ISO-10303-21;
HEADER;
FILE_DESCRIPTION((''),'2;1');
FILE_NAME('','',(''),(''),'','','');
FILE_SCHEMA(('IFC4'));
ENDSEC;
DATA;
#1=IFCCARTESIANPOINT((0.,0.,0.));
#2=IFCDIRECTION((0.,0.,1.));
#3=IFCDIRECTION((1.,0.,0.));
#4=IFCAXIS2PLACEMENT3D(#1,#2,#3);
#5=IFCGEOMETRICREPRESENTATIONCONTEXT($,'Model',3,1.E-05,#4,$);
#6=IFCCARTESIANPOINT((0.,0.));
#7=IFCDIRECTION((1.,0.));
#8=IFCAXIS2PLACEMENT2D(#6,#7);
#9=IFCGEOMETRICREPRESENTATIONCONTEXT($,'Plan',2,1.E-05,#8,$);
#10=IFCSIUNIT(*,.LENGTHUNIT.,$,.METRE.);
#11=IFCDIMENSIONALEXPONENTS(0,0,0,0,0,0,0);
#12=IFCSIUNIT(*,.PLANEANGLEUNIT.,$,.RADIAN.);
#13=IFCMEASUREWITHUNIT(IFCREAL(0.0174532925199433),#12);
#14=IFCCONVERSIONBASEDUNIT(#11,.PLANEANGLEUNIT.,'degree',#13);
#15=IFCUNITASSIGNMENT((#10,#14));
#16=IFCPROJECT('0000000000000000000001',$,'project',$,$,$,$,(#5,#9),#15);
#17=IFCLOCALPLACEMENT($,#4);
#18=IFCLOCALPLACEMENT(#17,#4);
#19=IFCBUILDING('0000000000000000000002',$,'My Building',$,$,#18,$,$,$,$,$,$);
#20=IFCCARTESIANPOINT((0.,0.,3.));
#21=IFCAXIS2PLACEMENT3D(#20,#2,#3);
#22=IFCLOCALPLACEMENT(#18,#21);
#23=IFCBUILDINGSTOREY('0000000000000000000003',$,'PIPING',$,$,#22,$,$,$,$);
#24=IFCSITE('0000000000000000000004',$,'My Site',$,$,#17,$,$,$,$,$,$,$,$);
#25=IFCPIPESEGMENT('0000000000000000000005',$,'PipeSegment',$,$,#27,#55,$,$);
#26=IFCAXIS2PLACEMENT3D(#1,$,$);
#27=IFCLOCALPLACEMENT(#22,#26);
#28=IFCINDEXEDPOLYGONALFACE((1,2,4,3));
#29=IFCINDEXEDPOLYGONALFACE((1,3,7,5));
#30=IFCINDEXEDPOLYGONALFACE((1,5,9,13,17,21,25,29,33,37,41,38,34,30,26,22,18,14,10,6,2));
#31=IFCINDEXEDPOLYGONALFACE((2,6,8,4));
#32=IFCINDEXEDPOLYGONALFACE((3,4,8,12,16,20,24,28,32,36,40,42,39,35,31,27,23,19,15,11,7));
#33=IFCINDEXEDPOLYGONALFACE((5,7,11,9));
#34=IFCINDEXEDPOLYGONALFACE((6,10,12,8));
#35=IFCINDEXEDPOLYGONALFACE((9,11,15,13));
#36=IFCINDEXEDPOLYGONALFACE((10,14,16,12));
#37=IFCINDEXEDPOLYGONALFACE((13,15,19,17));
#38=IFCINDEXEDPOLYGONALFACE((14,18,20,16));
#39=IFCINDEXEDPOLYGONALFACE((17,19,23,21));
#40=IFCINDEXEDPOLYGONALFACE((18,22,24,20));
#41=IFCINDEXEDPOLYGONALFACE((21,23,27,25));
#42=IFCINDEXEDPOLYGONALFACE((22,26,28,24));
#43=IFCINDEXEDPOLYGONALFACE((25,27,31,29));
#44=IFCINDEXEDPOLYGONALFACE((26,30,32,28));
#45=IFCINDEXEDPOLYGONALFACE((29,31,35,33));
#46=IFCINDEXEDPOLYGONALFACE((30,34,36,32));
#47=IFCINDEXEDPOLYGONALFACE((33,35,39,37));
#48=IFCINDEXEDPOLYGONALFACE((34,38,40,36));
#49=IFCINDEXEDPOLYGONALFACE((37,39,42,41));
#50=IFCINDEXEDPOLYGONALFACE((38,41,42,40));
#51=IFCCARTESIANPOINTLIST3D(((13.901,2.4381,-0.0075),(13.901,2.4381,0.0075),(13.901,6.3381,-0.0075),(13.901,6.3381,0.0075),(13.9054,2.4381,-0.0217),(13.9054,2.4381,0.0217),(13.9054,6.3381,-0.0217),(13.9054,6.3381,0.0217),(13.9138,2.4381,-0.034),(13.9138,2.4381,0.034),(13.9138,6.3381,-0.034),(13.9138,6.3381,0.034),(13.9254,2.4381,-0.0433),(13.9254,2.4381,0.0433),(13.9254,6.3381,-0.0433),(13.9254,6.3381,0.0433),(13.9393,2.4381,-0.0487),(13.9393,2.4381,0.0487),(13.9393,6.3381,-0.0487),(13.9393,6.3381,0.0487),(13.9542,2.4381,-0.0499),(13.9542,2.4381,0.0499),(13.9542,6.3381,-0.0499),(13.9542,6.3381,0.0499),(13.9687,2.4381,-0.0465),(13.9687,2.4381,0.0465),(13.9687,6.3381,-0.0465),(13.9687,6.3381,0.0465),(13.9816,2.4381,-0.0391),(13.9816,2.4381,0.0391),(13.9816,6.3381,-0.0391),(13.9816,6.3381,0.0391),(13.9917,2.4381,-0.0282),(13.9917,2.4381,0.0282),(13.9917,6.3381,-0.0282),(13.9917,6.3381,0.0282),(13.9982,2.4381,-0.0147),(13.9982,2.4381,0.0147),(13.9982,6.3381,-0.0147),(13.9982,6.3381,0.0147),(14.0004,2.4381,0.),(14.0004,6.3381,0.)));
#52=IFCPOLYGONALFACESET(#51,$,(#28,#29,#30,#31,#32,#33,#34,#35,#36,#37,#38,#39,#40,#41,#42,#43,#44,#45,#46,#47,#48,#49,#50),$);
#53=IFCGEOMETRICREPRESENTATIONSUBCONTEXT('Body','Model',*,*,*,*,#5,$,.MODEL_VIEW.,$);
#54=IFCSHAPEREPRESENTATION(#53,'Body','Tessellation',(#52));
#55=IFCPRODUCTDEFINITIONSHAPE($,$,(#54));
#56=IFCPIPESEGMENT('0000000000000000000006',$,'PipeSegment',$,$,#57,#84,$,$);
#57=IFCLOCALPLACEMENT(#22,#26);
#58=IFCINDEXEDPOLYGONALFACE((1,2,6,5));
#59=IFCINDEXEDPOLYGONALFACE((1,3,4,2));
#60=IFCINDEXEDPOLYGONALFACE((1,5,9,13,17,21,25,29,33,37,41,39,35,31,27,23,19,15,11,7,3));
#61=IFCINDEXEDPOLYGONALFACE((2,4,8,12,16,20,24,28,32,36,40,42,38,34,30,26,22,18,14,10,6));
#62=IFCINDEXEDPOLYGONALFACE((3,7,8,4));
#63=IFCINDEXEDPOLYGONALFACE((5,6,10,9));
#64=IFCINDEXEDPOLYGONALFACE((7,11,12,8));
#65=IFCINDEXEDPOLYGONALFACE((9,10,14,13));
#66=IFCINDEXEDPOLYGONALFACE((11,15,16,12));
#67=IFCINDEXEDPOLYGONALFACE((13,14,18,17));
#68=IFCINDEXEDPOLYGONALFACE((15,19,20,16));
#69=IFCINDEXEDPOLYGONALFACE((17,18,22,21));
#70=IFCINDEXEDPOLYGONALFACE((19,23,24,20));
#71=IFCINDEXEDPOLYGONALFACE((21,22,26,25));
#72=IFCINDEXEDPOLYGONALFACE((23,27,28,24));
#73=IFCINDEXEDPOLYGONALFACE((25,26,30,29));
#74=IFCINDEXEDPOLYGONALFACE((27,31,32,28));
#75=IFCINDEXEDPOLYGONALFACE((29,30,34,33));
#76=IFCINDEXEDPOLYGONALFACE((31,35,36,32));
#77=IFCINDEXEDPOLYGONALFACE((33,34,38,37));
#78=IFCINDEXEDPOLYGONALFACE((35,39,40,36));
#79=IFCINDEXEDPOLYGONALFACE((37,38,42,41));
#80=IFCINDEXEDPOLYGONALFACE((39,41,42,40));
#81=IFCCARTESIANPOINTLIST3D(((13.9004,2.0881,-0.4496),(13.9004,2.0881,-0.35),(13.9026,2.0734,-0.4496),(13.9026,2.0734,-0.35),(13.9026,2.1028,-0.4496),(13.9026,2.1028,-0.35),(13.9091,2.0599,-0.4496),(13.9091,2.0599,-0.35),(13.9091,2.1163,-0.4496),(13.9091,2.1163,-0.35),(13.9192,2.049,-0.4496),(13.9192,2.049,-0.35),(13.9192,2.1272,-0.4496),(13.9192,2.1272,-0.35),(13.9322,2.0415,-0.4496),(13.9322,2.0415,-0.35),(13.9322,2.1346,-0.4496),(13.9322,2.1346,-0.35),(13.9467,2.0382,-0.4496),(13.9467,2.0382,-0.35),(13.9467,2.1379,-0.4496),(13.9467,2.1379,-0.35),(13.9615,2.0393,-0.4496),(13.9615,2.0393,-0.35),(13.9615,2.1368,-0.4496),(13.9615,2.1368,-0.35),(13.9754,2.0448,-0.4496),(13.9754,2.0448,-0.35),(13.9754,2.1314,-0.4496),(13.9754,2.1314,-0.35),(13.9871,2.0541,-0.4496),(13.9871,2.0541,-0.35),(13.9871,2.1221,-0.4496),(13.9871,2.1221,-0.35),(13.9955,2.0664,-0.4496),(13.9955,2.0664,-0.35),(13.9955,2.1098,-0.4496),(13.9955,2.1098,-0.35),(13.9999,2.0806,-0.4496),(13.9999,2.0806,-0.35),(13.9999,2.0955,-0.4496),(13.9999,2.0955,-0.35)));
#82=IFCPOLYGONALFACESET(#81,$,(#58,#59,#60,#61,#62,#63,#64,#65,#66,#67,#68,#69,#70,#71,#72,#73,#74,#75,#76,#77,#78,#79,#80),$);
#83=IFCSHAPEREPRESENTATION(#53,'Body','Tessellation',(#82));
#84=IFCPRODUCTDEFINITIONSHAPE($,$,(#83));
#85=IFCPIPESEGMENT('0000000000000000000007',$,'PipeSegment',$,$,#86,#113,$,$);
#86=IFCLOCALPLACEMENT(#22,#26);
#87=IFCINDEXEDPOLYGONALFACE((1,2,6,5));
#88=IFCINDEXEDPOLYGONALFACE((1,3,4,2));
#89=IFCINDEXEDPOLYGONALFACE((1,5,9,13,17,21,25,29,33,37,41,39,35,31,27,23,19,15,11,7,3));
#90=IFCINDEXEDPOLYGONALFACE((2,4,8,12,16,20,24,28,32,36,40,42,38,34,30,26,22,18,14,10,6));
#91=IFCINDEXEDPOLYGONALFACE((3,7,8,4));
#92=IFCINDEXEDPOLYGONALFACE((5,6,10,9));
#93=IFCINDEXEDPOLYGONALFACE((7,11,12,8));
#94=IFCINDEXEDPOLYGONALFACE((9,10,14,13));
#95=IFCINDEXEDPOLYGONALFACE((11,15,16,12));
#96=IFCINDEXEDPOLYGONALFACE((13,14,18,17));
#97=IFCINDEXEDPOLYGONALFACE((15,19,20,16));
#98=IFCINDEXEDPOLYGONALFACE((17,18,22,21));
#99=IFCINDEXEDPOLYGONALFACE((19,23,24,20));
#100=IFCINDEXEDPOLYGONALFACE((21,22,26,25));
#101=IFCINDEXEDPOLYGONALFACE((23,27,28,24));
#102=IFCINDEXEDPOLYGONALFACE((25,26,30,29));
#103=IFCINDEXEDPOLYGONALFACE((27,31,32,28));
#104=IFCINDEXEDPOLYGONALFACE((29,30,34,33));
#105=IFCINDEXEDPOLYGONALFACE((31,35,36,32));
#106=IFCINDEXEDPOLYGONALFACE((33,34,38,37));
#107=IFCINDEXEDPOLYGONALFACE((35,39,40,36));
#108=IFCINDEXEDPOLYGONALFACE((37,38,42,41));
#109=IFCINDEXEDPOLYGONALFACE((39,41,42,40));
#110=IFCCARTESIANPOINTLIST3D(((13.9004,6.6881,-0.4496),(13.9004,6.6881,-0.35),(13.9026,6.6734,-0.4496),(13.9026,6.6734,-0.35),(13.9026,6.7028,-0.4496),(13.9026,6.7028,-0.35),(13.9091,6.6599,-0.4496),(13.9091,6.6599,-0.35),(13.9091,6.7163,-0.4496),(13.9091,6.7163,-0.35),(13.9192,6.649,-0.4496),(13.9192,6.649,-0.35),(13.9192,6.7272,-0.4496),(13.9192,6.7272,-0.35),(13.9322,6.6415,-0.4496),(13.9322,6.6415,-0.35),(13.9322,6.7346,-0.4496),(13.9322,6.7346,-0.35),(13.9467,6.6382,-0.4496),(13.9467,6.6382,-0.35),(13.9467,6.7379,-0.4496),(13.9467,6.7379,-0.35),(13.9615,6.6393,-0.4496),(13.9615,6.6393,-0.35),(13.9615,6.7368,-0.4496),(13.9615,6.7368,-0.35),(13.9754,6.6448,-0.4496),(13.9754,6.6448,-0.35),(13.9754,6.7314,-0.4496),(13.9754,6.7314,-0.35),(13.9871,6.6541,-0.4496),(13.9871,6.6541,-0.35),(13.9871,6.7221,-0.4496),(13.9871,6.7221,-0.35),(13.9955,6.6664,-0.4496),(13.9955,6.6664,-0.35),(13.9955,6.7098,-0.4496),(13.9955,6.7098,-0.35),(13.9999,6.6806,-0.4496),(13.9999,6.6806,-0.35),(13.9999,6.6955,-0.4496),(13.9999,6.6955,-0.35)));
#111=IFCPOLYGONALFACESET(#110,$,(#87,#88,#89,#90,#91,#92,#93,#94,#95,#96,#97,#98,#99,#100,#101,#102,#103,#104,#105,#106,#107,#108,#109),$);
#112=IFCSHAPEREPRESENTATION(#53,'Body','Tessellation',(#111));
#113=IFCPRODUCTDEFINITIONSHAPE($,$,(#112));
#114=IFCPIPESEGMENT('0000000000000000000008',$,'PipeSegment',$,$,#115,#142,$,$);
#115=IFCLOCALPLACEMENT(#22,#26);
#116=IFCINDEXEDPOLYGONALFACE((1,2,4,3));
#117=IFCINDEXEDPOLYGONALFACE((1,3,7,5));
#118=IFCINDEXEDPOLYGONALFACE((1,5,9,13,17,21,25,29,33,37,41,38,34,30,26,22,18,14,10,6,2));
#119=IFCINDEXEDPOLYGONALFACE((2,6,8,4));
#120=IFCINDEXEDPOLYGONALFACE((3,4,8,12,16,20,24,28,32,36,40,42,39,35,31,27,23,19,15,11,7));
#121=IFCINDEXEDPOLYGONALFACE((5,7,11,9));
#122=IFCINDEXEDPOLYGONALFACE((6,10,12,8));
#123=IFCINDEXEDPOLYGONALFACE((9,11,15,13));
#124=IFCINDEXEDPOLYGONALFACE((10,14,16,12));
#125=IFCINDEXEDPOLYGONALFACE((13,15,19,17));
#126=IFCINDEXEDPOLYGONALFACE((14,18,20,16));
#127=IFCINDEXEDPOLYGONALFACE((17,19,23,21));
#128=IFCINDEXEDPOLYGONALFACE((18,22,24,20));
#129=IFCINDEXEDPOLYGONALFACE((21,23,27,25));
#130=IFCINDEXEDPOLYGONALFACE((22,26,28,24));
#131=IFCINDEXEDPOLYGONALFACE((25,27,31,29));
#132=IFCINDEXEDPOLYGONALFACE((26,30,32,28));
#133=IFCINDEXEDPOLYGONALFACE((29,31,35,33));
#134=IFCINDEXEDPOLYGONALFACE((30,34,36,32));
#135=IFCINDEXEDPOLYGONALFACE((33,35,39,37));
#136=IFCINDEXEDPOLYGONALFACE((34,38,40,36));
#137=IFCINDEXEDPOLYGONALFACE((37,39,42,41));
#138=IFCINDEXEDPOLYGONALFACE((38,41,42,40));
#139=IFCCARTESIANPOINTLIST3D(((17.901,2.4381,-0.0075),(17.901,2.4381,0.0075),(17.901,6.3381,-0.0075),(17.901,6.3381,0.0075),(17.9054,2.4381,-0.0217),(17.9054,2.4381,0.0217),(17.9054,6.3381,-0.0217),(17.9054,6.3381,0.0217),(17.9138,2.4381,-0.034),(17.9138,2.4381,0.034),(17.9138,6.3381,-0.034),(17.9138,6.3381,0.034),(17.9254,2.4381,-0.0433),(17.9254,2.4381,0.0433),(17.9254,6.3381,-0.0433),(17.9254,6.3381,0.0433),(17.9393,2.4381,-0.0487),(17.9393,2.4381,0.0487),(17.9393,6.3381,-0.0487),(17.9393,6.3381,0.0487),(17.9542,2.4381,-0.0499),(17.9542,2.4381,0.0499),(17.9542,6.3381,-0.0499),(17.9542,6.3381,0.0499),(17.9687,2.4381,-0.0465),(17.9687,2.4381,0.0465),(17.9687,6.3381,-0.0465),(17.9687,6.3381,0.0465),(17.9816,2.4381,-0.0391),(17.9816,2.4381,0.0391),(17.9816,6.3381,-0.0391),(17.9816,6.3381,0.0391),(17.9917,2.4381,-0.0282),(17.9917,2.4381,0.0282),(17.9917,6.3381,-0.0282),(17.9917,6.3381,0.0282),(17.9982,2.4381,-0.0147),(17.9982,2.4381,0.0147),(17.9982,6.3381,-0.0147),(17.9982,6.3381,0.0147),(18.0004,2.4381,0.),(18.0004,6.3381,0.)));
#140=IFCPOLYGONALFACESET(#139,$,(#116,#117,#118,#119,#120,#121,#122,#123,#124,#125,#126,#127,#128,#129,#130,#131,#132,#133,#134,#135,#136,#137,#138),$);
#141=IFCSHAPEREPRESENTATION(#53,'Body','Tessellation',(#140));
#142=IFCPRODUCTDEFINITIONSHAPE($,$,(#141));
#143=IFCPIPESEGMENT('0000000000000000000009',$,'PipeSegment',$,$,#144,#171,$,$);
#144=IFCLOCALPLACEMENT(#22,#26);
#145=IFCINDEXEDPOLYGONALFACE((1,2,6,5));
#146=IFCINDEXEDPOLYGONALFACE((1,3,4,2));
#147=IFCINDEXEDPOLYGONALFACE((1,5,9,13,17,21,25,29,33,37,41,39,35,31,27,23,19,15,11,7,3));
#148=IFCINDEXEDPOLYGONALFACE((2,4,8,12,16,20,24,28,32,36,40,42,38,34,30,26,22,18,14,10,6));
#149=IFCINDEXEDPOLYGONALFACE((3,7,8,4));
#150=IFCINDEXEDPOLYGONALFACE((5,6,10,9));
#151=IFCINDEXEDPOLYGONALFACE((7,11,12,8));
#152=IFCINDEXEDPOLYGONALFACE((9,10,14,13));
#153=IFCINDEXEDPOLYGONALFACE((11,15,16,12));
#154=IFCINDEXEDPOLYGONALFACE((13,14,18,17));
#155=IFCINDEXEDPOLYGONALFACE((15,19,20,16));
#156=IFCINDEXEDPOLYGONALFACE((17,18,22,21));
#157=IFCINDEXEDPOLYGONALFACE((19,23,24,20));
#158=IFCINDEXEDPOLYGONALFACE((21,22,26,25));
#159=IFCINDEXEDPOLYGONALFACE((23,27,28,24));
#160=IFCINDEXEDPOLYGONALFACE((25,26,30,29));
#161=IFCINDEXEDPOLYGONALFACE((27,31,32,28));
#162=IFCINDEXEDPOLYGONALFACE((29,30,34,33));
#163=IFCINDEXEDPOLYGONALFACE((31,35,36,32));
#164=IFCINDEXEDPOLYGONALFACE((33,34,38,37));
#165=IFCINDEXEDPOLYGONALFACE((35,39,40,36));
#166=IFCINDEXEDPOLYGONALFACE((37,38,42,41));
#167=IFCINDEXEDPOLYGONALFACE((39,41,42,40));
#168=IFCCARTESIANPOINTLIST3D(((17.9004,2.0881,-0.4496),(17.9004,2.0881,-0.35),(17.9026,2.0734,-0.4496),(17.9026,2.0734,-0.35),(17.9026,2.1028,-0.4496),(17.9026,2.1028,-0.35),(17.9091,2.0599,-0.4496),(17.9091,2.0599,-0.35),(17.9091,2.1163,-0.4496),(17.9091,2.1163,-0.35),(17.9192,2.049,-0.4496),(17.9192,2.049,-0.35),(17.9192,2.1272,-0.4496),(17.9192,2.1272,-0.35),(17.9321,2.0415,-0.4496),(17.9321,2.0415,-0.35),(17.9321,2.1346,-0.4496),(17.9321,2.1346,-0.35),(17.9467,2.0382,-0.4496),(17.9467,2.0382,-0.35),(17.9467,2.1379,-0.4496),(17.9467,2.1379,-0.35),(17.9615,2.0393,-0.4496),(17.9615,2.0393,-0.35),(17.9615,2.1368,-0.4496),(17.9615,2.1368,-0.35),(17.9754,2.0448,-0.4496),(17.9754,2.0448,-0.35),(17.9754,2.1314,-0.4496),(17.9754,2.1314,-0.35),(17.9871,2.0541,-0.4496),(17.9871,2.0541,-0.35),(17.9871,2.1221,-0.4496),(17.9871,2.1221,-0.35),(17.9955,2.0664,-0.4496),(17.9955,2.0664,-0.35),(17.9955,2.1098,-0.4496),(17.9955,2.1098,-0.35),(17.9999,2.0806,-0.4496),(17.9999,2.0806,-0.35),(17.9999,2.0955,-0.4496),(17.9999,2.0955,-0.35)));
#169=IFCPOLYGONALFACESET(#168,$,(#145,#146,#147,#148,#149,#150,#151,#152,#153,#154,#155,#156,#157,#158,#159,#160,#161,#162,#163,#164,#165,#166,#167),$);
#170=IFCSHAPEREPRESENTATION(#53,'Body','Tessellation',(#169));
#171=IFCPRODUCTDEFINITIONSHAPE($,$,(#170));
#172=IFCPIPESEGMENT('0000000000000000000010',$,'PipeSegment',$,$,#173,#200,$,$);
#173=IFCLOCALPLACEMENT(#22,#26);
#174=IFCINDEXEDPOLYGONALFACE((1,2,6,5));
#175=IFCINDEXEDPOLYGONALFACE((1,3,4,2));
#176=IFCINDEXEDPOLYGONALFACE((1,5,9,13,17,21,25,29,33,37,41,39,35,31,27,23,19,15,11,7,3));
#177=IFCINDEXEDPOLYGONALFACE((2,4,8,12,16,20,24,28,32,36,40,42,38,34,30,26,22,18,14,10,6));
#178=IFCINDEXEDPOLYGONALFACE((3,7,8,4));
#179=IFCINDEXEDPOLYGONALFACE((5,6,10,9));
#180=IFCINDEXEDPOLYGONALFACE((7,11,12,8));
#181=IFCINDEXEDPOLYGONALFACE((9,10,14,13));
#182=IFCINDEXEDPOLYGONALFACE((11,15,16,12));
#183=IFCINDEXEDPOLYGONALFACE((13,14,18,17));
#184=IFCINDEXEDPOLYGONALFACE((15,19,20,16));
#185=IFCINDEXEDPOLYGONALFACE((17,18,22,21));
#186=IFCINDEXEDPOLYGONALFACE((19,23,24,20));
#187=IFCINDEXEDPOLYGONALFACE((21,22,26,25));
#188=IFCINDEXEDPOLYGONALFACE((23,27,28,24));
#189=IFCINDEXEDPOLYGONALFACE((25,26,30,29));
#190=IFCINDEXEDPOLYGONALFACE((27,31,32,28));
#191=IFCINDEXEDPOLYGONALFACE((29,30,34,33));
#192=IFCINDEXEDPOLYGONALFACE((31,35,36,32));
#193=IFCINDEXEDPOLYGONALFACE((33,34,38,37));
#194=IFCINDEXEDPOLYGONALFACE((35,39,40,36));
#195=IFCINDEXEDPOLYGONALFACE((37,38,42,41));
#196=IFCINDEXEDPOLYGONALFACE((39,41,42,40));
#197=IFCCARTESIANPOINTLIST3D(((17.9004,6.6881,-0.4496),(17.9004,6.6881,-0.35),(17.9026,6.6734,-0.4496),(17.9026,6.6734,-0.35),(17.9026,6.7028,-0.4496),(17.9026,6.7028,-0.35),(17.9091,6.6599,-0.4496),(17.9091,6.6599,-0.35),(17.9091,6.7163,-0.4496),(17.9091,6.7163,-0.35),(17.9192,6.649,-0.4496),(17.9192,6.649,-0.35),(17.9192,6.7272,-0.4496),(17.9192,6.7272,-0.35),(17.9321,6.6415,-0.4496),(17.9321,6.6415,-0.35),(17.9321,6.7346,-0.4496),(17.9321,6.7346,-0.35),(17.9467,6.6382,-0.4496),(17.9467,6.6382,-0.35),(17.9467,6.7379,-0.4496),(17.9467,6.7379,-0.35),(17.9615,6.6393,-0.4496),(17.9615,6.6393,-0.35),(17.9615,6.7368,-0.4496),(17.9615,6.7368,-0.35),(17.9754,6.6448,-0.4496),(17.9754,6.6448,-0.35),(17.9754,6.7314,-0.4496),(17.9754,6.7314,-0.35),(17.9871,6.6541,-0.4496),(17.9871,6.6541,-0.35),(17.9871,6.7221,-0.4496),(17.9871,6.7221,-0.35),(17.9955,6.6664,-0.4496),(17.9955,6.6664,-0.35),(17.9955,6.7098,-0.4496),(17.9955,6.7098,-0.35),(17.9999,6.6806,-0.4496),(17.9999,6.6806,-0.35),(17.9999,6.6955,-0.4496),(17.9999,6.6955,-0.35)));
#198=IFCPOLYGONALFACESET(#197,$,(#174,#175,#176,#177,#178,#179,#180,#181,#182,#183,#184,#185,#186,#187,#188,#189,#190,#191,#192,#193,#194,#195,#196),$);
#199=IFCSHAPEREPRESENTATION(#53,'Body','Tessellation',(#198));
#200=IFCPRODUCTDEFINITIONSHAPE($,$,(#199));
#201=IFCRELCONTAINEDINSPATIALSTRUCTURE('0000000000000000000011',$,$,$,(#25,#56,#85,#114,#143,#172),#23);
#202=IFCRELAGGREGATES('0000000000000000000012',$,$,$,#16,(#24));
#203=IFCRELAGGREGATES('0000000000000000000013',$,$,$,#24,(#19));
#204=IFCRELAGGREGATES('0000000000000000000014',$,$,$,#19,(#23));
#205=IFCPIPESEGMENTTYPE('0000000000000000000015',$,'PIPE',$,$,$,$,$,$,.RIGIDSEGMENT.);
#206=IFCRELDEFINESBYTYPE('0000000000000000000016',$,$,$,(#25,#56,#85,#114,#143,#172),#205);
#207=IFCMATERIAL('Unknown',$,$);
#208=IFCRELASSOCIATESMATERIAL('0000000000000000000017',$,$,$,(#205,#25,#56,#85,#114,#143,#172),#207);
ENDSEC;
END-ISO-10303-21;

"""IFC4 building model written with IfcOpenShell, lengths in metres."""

from ifc_helpers import new_model, entity, si_unit, converted_unit, frame, origin_with_axes, origin_2d_with_axis, place, context, subcontext, project, spatial, circle, extrude, material, material_profile, profile_set, profile_usage, type_object, element, save


model = new_model("IFC4")

# Units and contexts
model_context = context("Model", 3, precision=1e-05, world=origin_with_axes())
plan_context = context("Plan", 2, precision=1e-05, world=origin_2d_with_axis())
body_context = subcontext(model_context, "Body", "Model", "MODEL_VIEW")
ifc_project = project(units=[si_unit("LENGTHUNIT", "METRE"), converted_unit("PLANEANGLEUNIT", "degree", entity("IfcReal", 0.0174532925199433), si_unit("PLANEANGLEUNIT", "RADIAN"), dimensions=[0, 0, 0, 0, 0, 0, 0])], contexts=[model_context, plan_context])

# Site, building, storey
site_placement = place(None, origin_with_axes())
site = spatial("IfcSite", under=ifc_project, at=site_placement, Name="My Site")
building_placement = place(site_placement, origin_with_axes())
building = spatial("IfcBuilding", under=site, at=building_placement, Name="My Building")
storey_placement = place(building_placement, frame((0.0, 0.0, 3.0), z_axis=(0.0, 0.0, 1.0), x_axis=(1.0, 0.0, 0.0)))
storey = spatial("IfcBuildingStorey", under=building, at=storey_placement, Name="PIPING")

# Pipe segments
ifc_material = material(Name="Unknown")
ifc_material_profile = material_profile(ifc_material, circle(Radius=0.05))
ifc_profile_set = profile_set([ifc_material_profile])
pipe_segment_type = type_object("IfcPipeSegmentType", Name="PIPE", PredefinedType="RIGIDSEGMENT", material=ifc_profile_set)
ifc_profile_usage_1 = profile_usage(ifc_profile_set, cardinal=5)
pipe_segment_1_placement = place(storey_placement, frame((13.9504, 6.3381, 0.0), z_axis=(0.0, -1.0, 0.0), x_axis=(1.0, 0.0, 0.0)))
element("IfcPipeSegment", 1, at=pipe_segment_1_placement, inside=storey, type_object=pipe_segment_type, material=ifc_profile_usage_1, Name="PipeSegment", context=body_context, shape_type="SweptSolid", body=[
    extrude(circle(Radius=0.05), origin_with_axes(), (0.0, 0.0, 1.0), 3.9),
])
ifc_profile_usage_2 = profile_usage(ifc_profile_set, cardinal=5)
pipe_segment_2_placement = place(storey_placement, frame((13.9504, 2.0881, -0.35), z_axis=(0.0, 0.0, -1.0), x_axis=(-1.0, 0.0, 0.0)))
element("IfcPipeSegment", 2, at=pipe_segment_2_placement, inside=storey, type_object=pipe_segment_type, material=ifc_profile_usage_2, Name="PipeSegment", context=body_context, shape_type="SweptSolid", body=[
    extrude(circle(Radius=0.05), origin_with_axes(), (0.0, 0.0, 1.0), 0.0996),
])
ifc_profile_usage_3 = profile_usage(ifc_profile_set, cardinal=5)
pipe_segment_3_placement = place(storey_placement, frame((13.9504, 6.6881, -0.35), z_axis=(0.0, 0.0, -1.0), x_axis=(-1.0, 0.0, 0.0)))
element("IfcPipeSegment", 3, at=pipe_segment_3_placement, inside=storey, type_object=pipe_segment_type, material=ifc_profile_usage_3, Name="PipeSegment", context=body_context, shape_type="SweptSolid", body=[
    extrude(circle(Radius=0.05), origin_with_axes(), (0.0, 0.0, 1.0), 0.0996),
])
ifc_profile_usage_4 = profile_usage(ifc_profile_set, cardinal=5)
pipe_segment_4_placement = place(storey_placement, frame((17.9504, 6.3381, 0.0), z_axis=(0.0, -1.0, 0.0), x_axis=(1.0, 0.0, 0.0)))
element("IfcPipeSegment", 4, at=pipe_segment_4_placement, inside=storey, type_object=pipe_segment_type, material=ifc_profile_usage_4, Name="PipeSegment", context=body_context, shape_type="SweptSolid", body=[
    extrude(circle(Radius=0.05), origin_with_axes(), (0.0, 0.0, 1.0), 3.9),
])
ifc_profile_usage_5 = profile_usage(ifc_profile_set, cardinal=5)
pipe_segment_5_placement = place(storey_placement, frame((17.9504, 2.0881, -0.35), z_axis=(0.0, 0.0, -1.0), x_axis=(-1.0, 0.0, 0.0)))
element("IfcPipeSegment", 5, at=pipe_segment_5_placement, inside=storey, type_object=pipe_segment_type, material=ifc_profile_usage_5, Name="PipeSegment", context=body_context, shape_type="SweptSolid", body=[
    extrude(circle(Radius=0.05), origin_with_axes(), (0.0, 0.0, 1.0), 0.0996),
])
ifc_profile_usage_6 = profile_usage(ifc_profile_set, cardinal=5)
pipe_segment_6_placement = place(storey_placement, frame((17.9504, 6.6881, -0.35), z_axis=(0.0, 0.0, -1.0), x_axis=(-1.0, 0.0, 0.0)))
element("IfcPipeSegment", 6, at=pipe_segment_6_placement, inside=storey, type_object=pipe_segment_type, material=ifc_profile_usage_6, Name="PipeSegment", context=body_context, shape_type="SweptSolid", body=[
    extrude(circle(Radius=0.05), origin_with_axes(), (0.0, 0.0, 1.0), 0.0996),
])

save(model, "model.ifc")
